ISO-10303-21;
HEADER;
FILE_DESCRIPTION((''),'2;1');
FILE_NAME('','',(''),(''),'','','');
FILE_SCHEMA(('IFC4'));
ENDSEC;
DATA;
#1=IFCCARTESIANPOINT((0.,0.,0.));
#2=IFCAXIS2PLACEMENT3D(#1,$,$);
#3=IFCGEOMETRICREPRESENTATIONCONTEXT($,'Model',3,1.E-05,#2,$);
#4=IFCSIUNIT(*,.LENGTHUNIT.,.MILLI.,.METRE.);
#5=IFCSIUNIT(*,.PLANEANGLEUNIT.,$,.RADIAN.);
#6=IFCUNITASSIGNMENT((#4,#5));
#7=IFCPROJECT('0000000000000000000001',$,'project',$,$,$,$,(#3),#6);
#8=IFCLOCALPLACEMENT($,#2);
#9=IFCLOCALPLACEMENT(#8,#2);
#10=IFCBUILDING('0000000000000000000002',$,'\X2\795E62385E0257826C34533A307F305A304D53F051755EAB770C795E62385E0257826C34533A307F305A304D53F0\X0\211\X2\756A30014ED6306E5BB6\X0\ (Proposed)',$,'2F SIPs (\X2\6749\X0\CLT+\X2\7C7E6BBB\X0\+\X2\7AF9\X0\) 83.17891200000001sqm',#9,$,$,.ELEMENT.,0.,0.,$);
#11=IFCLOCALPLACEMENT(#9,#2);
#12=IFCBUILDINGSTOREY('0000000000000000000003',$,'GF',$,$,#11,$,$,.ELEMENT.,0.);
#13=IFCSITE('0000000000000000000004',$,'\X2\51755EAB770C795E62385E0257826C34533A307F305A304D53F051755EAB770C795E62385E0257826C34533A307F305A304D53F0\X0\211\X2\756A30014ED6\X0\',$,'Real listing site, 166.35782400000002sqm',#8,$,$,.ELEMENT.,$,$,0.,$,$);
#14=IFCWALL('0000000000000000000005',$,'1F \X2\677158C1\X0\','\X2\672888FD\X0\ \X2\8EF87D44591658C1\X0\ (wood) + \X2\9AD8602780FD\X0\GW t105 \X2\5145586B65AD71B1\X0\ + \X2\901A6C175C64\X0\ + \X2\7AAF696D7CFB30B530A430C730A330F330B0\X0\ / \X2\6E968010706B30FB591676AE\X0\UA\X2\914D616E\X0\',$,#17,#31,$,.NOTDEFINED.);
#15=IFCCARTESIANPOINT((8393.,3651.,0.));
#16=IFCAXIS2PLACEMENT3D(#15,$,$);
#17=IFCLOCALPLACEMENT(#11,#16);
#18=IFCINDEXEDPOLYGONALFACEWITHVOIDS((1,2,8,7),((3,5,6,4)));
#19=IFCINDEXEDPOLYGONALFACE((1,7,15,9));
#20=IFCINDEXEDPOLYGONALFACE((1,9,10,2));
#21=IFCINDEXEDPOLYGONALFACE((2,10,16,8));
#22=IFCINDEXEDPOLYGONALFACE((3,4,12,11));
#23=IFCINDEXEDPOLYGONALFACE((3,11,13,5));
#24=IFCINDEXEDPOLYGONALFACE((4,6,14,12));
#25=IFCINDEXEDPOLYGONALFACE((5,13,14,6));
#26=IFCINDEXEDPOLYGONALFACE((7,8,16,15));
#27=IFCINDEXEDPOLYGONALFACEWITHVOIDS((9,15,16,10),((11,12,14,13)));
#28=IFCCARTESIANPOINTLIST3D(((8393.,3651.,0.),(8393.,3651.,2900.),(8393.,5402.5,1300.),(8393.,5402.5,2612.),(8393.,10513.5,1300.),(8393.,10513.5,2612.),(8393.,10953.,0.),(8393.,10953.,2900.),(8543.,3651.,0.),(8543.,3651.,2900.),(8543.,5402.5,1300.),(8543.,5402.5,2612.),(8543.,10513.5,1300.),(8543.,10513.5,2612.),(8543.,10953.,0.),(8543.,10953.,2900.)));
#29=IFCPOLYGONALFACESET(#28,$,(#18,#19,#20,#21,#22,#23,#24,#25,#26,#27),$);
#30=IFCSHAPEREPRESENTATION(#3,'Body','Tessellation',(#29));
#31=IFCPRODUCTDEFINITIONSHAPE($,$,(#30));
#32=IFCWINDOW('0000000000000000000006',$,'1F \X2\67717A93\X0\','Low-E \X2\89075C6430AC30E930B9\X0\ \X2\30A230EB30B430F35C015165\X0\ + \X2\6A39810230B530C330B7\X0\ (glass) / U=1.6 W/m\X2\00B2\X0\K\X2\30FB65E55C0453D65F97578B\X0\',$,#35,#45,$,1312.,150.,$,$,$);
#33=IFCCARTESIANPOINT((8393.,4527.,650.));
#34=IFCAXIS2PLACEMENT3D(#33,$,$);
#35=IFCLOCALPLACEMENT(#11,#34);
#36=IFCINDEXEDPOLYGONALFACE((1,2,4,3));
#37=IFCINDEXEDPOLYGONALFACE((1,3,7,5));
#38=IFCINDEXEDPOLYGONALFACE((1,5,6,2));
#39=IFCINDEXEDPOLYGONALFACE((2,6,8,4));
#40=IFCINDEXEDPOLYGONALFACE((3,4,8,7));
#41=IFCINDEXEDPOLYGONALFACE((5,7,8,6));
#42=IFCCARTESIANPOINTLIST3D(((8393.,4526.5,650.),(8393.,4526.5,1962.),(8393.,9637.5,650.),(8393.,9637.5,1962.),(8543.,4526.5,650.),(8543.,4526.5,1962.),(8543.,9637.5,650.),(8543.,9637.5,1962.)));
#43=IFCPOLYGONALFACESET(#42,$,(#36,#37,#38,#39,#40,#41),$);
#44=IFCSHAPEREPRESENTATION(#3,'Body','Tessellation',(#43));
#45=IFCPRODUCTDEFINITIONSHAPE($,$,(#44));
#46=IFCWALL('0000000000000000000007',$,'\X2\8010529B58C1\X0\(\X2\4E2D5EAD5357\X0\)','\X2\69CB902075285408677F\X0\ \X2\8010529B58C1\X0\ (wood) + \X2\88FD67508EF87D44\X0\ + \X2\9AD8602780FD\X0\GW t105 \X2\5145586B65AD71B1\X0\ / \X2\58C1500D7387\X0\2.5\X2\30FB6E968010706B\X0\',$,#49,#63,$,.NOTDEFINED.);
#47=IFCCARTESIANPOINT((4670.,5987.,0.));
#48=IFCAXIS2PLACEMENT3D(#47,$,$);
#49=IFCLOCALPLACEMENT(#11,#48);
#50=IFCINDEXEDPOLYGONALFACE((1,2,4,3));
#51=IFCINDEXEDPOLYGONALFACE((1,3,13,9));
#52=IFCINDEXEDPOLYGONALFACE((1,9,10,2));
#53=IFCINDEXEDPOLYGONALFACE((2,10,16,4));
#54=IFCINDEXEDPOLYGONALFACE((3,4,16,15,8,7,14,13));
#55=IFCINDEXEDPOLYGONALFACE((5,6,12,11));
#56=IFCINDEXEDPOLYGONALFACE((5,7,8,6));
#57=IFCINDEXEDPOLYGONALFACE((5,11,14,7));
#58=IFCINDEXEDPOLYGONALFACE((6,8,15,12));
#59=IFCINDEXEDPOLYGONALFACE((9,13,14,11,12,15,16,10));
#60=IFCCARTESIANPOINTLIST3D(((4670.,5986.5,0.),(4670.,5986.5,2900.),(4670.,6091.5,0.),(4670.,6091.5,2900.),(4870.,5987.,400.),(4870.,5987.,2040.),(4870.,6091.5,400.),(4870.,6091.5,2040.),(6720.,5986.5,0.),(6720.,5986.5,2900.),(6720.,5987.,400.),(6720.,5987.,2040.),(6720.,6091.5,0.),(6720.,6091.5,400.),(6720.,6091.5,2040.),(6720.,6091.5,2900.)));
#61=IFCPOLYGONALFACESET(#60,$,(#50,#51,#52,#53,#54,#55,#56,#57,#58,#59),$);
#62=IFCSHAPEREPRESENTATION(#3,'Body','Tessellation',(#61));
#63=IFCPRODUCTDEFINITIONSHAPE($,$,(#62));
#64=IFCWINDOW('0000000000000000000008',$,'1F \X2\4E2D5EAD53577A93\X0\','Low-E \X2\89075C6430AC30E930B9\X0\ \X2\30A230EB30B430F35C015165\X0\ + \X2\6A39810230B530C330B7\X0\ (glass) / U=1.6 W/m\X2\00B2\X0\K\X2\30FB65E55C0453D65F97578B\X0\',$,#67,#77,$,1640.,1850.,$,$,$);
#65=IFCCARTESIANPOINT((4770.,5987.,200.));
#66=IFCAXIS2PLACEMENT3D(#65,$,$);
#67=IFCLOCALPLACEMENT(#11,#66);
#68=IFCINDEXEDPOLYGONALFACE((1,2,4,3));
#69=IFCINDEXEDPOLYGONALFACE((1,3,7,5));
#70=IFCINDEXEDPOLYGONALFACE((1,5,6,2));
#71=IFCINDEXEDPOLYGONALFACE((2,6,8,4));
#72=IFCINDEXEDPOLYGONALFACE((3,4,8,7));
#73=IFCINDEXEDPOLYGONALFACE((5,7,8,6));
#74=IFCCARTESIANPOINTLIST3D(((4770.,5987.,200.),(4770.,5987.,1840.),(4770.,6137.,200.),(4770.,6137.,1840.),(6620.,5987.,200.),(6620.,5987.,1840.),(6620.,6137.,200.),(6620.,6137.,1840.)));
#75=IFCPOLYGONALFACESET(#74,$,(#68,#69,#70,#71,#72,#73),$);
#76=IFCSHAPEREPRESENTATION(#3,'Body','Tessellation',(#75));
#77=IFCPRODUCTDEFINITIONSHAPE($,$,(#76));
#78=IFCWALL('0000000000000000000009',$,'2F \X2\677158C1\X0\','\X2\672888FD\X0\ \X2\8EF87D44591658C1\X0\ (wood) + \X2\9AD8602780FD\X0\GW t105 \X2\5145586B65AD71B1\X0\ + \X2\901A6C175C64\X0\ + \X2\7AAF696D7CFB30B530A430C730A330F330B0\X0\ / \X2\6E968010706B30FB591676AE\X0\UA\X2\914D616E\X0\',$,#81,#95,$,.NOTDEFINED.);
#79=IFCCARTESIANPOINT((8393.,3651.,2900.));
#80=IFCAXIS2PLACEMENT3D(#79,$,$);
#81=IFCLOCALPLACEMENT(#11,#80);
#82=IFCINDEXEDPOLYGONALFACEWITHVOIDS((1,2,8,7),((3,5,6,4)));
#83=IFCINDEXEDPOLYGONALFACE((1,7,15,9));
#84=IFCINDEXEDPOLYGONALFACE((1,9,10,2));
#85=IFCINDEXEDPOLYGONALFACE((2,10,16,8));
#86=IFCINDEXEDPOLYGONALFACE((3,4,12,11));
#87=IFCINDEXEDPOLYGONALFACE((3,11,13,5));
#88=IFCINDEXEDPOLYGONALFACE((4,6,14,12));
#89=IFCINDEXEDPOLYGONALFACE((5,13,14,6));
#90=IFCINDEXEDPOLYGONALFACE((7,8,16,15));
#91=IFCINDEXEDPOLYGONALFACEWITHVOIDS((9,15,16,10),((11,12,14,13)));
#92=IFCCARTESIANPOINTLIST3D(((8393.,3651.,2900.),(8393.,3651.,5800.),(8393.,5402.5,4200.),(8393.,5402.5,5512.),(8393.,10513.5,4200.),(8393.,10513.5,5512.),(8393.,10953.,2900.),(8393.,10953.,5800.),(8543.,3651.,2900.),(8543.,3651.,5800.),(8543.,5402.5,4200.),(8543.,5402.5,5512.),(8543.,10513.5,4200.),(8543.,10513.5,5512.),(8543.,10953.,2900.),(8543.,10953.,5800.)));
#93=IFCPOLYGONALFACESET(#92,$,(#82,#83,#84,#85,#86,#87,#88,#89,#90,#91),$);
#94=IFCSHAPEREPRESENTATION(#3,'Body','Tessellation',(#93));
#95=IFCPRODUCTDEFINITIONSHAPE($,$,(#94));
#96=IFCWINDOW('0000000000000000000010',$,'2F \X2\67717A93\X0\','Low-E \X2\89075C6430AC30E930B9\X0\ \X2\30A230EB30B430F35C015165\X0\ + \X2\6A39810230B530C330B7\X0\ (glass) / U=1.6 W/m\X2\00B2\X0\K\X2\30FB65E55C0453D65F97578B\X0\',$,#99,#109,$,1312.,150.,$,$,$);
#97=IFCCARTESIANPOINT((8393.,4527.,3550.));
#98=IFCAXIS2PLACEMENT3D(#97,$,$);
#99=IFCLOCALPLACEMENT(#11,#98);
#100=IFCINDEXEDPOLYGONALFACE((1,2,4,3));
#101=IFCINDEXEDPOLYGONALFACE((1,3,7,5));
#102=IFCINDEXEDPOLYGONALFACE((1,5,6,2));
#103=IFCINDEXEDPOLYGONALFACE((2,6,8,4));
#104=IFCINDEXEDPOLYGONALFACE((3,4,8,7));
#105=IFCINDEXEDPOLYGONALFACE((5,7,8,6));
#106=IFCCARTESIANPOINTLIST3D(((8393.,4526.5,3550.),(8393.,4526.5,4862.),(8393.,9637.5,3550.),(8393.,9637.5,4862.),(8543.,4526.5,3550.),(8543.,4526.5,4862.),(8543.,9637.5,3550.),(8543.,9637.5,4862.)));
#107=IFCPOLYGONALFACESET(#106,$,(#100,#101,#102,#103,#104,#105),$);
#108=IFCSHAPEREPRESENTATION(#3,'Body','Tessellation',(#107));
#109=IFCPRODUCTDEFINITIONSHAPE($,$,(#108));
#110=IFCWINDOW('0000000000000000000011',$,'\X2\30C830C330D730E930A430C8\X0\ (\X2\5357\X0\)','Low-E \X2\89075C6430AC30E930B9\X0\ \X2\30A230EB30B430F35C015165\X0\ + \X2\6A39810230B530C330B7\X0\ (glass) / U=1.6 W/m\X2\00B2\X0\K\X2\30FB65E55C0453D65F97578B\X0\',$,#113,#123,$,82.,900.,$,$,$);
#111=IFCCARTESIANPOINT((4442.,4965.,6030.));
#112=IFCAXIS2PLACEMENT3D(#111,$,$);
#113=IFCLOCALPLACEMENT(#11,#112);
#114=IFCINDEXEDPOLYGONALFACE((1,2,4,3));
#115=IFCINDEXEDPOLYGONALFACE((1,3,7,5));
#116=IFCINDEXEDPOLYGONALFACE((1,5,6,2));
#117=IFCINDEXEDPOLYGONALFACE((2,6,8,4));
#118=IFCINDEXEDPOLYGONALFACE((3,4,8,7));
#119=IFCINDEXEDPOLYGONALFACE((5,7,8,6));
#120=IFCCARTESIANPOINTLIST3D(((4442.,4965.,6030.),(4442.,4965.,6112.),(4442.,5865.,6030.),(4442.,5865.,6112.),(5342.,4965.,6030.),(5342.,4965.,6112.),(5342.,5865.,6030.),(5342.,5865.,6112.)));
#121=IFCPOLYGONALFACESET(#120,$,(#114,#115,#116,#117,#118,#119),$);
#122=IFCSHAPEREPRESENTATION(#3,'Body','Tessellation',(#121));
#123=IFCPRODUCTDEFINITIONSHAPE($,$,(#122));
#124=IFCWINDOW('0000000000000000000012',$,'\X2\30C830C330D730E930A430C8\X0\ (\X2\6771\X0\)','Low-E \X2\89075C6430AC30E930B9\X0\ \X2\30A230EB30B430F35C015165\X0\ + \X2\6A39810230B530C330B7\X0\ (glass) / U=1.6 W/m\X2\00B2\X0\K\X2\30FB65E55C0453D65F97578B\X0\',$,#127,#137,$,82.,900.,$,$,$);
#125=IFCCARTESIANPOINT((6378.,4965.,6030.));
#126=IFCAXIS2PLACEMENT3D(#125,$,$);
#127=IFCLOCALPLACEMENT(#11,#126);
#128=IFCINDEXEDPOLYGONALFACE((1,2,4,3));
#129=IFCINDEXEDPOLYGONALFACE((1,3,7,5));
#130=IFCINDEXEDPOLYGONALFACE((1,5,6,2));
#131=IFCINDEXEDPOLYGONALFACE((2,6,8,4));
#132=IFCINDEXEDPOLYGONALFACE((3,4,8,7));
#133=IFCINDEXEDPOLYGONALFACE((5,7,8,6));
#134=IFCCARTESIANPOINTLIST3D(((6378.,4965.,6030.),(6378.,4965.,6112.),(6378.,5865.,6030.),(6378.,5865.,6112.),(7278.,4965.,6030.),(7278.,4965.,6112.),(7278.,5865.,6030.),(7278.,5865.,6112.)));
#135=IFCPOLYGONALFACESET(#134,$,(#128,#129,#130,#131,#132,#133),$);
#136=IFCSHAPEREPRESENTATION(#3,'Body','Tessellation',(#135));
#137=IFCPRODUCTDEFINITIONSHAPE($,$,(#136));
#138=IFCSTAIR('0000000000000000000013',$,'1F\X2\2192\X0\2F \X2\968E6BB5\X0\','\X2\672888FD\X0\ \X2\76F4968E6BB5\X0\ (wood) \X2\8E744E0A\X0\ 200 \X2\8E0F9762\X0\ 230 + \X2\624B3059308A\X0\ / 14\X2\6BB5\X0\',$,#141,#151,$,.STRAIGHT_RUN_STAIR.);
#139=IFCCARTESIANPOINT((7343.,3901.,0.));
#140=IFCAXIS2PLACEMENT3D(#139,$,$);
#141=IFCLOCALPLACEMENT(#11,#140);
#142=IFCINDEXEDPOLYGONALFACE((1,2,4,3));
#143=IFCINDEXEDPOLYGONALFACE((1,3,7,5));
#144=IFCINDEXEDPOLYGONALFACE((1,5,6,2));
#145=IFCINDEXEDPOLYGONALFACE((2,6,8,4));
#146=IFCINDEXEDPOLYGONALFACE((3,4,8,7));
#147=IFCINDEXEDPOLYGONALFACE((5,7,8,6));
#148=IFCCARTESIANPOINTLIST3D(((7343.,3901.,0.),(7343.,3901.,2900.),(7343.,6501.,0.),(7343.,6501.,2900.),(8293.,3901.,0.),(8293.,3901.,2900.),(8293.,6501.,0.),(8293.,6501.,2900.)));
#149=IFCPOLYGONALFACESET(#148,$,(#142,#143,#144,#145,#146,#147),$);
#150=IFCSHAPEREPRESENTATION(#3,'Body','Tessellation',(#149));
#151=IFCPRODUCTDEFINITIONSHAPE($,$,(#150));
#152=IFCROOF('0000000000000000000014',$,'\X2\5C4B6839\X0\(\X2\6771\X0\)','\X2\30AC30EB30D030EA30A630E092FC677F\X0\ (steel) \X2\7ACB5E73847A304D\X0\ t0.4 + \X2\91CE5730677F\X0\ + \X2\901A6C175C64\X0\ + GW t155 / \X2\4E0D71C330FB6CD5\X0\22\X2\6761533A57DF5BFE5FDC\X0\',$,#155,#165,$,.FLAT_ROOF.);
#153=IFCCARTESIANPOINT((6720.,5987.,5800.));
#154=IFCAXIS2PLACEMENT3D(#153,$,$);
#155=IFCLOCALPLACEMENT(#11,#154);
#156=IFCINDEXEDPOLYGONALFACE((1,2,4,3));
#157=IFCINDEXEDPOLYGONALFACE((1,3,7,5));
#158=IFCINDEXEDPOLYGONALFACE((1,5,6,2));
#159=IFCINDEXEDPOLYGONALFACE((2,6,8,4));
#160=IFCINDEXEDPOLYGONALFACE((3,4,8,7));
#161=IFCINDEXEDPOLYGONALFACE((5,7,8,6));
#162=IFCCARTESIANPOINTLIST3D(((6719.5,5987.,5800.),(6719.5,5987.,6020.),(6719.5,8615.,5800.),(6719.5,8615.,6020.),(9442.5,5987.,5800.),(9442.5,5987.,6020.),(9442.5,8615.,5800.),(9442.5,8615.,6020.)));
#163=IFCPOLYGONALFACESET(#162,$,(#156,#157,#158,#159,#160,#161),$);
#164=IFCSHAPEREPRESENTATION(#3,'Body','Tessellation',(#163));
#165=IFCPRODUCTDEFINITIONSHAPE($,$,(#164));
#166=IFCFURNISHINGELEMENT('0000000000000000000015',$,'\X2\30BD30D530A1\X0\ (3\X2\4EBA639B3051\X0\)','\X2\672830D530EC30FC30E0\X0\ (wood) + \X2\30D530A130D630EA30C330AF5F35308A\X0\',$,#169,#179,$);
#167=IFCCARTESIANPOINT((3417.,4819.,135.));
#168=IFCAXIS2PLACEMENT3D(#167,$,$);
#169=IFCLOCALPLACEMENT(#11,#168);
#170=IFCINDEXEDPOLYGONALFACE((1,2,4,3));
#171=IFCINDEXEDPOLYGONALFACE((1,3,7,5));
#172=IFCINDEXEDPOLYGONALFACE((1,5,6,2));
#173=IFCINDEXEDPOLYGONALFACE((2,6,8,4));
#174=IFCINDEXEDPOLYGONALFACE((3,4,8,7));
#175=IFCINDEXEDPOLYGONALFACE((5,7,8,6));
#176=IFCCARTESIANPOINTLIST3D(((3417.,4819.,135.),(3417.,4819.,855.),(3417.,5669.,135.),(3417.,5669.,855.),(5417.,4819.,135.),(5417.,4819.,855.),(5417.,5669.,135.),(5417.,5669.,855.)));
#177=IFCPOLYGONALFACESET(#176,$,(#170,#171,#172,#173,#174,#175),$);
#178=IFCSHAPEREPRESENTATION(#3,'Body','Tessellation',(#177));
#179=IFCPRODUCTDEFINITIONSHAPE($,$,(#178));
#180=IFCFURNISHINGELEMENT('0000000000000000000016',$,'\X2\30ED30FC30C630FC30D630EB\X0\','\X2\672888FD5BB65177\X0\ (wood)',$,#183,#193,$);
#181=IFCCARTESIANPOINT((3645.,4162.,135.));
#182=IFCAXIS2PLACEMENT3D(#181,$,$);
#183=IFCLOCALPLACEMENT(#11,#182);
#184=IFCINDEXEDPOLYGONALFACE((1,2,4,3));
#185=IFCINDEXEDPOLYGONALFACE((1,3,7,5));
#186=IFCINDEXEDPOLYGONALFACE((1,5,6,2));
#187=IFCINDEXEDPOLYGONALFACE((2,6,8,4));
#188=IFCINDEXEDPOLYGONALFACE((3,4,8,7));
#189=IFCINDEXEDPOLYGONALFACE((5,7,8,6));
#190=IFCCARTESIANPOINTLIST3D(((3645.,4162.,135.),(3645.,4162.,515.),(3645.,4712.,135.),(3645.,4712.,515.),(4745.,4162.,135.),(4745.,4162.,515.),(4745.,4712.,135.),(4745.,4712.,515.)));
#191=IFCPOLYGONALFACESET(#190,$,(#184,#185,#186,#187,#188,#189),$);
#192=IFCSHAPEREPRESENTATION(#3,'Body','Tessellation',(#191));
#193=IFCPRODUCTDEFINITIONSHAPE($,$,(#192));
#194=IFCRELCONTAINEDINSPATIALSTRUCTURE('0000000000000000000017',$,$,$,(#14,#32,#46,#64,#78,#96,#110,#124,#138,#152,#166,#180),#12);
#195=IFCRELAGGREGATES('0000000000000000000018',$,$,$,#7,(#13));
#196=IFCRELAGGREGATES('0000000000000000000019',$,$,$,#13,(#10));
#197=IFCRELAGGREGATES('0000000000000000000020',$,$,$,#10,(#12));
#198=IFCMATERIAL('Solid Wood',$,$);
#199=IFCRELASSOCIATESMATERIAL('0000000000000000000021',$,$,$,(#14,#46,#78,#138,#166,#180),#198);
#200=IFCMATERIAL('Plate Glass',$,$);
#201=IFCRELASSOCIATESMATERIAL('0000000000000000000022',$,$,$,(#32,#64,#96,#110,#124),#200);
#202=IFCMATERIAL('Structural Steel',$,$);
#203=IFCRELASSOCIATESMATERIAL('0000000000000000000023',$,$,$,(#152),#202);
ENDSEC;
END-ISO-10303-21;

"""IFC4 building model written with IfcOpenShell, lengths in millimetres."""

from ifc_helpers import new_model, si_unit, frame, frame_2d, origin, place, context, project, spatial, rectangle, extrude, material, element, fill, save


model = new_model("IFC4")

# Units and contexts
model_context = context("Model", 3, precision=1e-05, world=origin())
ifc_project = project(units=[si_unit("LENGTHUNIT", "METRE", prefix="MILLI"), si_unit("PLANEANGLEUNIT", "RADIAN")], contexts=[model_context])

# Site, building, storey
site_placement = place(None, origin())
site = spatial("IfcSite", under=ifc_project, at=site_placement, Name="兵庫県神戸市垂水区みずき台兵庫県神戸市垂水区みずき台211番、他", ObjectType="Real listing site, 166.35782400000002sqm", CompositionType="ELEMENT", RefElevation=0.0)
building_placement = place(site_placement, origin())
building = spatial("IfcBuilding", under=site, at=building_placement, Name="神戸市垂水区みずき台兵庫県神戸市垂水区みずき台211番、他の家 (Proposed)", ObjectType="2F SIPs (杉CLT+籾殻+竹) 83.17891200000001sqm", CompositionType="ELEMENT", ElevationOfRefHeight=0.0, ElevationOfTerrain=0.0)
storey_placement = place(building_placement, origin())
storey = spatial("IfcBuildingStorey", under=building, at=storey_placement, Name="GF", CompositionType="ELEMENT", Elevation=0.0)

# Shared definitions
ifc_material_1 = material(Name="Solid Wood")

# Walls, openings, windows
wall_1_placement = place(storey_placement, frame((8393.0, 3651.0, 0.0)))
wall_1 = element("IfcWall", 1, at=wall_1_placement, inside=storey, material=ifc_material_1, Name="1F 東壁", Description="木製 軸組外壁 (wood) + 高性能GW t105 充填断熱 + 通気層 + 窯業系サイディング / 準耐火・外皮UA配慮", PredefinedType="NOTDEFINED", context=model_context, shape_type="SweptSolid", body=[
    extrude(rectangle(XDim=150.0, YDim=7302.0, at=frame_2d((75.0, 3651.0))), frame((8393.0, 3651.0, 0.0)), (0.0, 0.0, 1.0), 2900.0),
])
opening_1_placement = place(storey_placement, frame((8393.0, 4527.0, 650.0)))
opening_1 = element("IfcOpeningElement", 2, at=opening_1_placement, cuts=wall_1, PredefinedType="NOTDEFINED", context=model_context, shape_type="SweptSolid", body=[
    extrude(rectangle(XDim=150.0, YDim=5111.0, at=frame_2d((75.0, 2555.0))), frame((8393.0, 4527.0, 650.0)), (0.0, 0.0, 1.0), 1312.0),
])
ifc_material_2 = material(Name="Plate Glass")
window_1_placement = place(storey_placement, frame((8393.0, 4527.0, 650.0)))
window_1 = element("IfcWindow", 3, at=window_1_placement, inside=storey, material=ifc_material_2, Name="1F 東窓", Description="Low-E 複層ガラス アルゴン封入 + 樹脂サッシ (glass) / U=1.6 W/m²K・日射取得型", OverallHeight=1312.0, OverallWidth=150.0, context=model_context, shape_type="SweptSolid", body=[
    extrude(rectangle(XDim=150.0, YDim=5111.0, at=frame_2d((75.0, 2555.0))), frame((8393.0, 4527.0, 650.0)), (0.0, 0.0, 1.0), 1312.0),
])
fill(opening_1, window_1)
wall_2_placement = place(storey_placement, frame((4670.0, 5987.0, 0.0)))
wall_2 = element("IfcWall", 4, at=wall_2_placement, inside=storey, material=ifc_material_1, Name="耐力壁(中庭南)", Description="構造用合板 耐力壁 (wood) + 製材軸組 + 高性能GW t105 充填断熱 / 壁倍率2.5・準耐火", PredefinedType="NOTDEFINED", context=model_context, shape_type="SweptSolid", body=[
    extrude(rectangle(XDim=2050.0, YDim=105.0, at=frame_2d((1025.0, 52.0))), frame((4670.0, 5987.0, 0.0)), (0.0, 0.0, 1.0), 2900.0),
])
opening_2_placement = place(storey_placement, frame((4770.0, 5987.0, 200.0)))
opening_2 = element("IfcOpeningElement", 5, at=opening_2_placement, cuts=wall_2, PredefinedType="NOTDEFINED", context=model_context, shape_type="SweptSolid", body=[
    extrude(rectangle(XDim=1850.0, YDim=150.0, at=frame_2d((925.0, 75.0))), frame((4770.0, 5987.0, 200.0)), (0.0, 0.0, 1.0), 1640.0),
])
window_2_placement = place(storey_placement, frame((4770.0, 5987.0, 200.0)))
window_2 = element("IfcWindow", 6, at=window_2_placement, inside=storey, material=ifc_material_2, Name="1F 中庭南窓", Description="Low-E 複層ガラス アルゴン封入 + 樹脂サッシ (glass) / U=1.6 W/m²K・日射取得型", OverallHeight=1640.0, OverallWidth=1850.0, context=model_context, shape_type="SweptSolid", body=[
    extrude(rectangle(XDim=1850.0, YDim=150.0, at=frame_2d((925.0, 75.0))), frame((4770.0, 5987.0, 200.0)), (0.0, 0.0, 1.0), 1640.0),
])
fill(opening_2, window_2)

# Wall, opening, window
wall_3_placement = place(storey_placement, frame((8393.0, 3651.0, 2900.0)))
wall_3 = element("IfcWall", 7, at=wall_3_placement, inside=storey, material=ifc_material_1, Name="2F 東壁", Description="木製 軸組外壁 (wood) + 高性能GW t105 充填断熱 + 通気層 + 窯業系サイディング / 準耐火・外皮UA配慮", PredefinedType="NOTDEFINED", context=model_context, shape_type="SweptSolid", body=[
    extrude(rectangle(XDim=150.0, YDim=7302.0, at=frame_2d((75.0, 3651.0))), frame((8393.0, 3651.0, 2900.0)), (0.0, 0.0, 1.0), 2900.0),
])
opening_3_placement = place(storey_placement, frame((8393.0, 4527.0, 3550.0)))
opening_3 = element("IfcOpeningElement", 8, at=opening_3_placement, cuts=wall_3, PredefinedType="NOTDEFINED", context=model_context, shape_type="SweptSolid", body=[
    extrude(rectangle(XDim=150.0, YDim=5111.0, at=frame_2d((75.0, 2555.0))), frame((8393.0, 4527.0, 3550.0)), (0.0, 0.0, 1.0), 1312.0),
])
window_3_placement = place(storey_placement, frame((8393.0, 4527.0, 3550.0)))
window_3 = element("IfcWindow", 9, at=window_3_placement, inside=storey, material=ifc_material_2, Name="2F 東窓", Description="Low-E 複層ガラス アルゴン封入 + 樹脂サッシ (glass) / U=1.6 W/m²K・日射取得型", OverallHeight=1312.0, OverallWidth=150.0, context=model_context, shape_type="SweptSolid", body=[
    extrude(rectangle(XDim=150.0, YDim=5111.0, at=frame_2d((75.0, 2555.0))), frame((8393.0, 4527.0, 3550.0)), (0.0, 0.0, 1.0), 1312.0),
])
fill(opening_3, window_3)

# Windows
window_4_placement = place(storey_placement, frame((4442.0, 4965.0, 6030.0)))
element("IfcWindow", 10, at=window_4_placement, inside=storey, material=ifc_material_2, Name="トップライト (南)", Description="Low-E 複層ガラス アルゴン封入 + 樹脂サッシ (glass) / U=1.6 W/m²K・日射取得型", OverallHeight=82.0, OverallWidth=900.0, context=model_context, shape_type="SweptSolid", body=[
    extrude(rectangle(XDim=900.0, YDim=900.0, at=frame_2d((450.0, 450.0))), frame((4442.0, 4965.0, 6030.0)), (0.0, 0.0, 1.0), 82.0),
])
window_5_placement = place(storey_placement, frame((6378.0, 4965.0, 6030.0)))
element("IfcWindow", 11, at=window_5_placement, inside=storey, material=ifc_material_2, Name="トップライト (東)", Description="Low-E 複層ガラス アルゴン封入 + 樹脂サッシ (glass) / U=1.6 W/m²K・日射取得型", OverallHeight=82.0, OverallWidth=900.0, context=model_context, shape_type="SweptSolid", body=[
    extrude(rectangle(XDim=900.0, YDim=900.0, at=frame_2d((450.0, 450.0))), frame((6378.0, 4965.0, 6030.0)), (0.0, 0.0, 1.0), 82.0),
])

# Stair
stair_placement = place(storey_placement, frame((7343.0, 3901.0, 0.0)))
element("IfcStair", 12, at=stair_placement, inside=storey, material=ifc_material_1, Name="1F→2F 階段", Description="木製 直階段 (wood) 蹴上 200 踏面 230 + 手すり / 14段", PredefinedType="STRAIGHT_RUN_STAIR", context=model_context, shape_type="SweptSolid", body=[
    extrude(rectangle(XDim=950.0, YDim=2600.0, at=frame_2d((475.0, 1300.0))), frame((7343.0, 3901.0, 0.0)), (0.0, 0.0, 1.0), 2900.0),
])

# Roof
ifc_material_3 = material(Name="Structural Steel")
roof_placement = place(storey_placement, frame((6720.0, 5987.0, 5800.0)))
element("IfcRoof", 13, at=roof_placement, inside=storey, material=ifc_material_3, Name="屋根(東)", Description="ガルバリウム鋼板 (steel) 立平葺き t0.4 + 野地板 + 通気層 + GW t155 / 不燃・法22条区域対応", PredefinedType="FLAT_ROOF", context=model_context, shape_type="SweptSolid", body=[
    extrude(rectangle(XDim=2723.0, YDim=2628.0, at=frame_2d((1361.0, 1314.0))), frame((6720.0, 5987.0, 5800.0)), (0.0, 0.0, 1.0), 220.0),
])

# Furnishing elements
furnishing_1_placement = place(storey_placement, frame((3417.0, 4819.0, 135.0)))
element("IfcFurnishingElement", 14, at=furnishing_1_placement, inside=storey, material=ifc_material_1, Name="ソファ (3人掛け)", Description="木フレーム (wood) + ファブリック張り", context=model_context, shape_type="SweptSolid", body=[
    extrude(rectangle(XDim=2000.0, YDim=850.0, at=frame_2d((1000.0, 425.0))), frame((3417.0, 4819.0, 135.0)), (0.0, 0.0, 1.0), 720.0),
])
furnishing_2_placement = place(storey_placement, frame((3645.0, 4162.0, 135.0)))
element("IfcFurnishingElement", 15, at=furnishing_2_placement, inside=storey, material=ifc_material_1, Name="ローテーブル", Description="木製家具 (wood)", context=model_context, shape_type="SweptSolid", body=[
    extrude(rectangle(XDim=1100.0, YDim=550.0, at=frame_2d((550.0, 275.0))), frame((3645.0, 4162.0, 135.0)), (0.0, 0.0, 1.0), 380.0),
])

save(model, "model.ifc")
